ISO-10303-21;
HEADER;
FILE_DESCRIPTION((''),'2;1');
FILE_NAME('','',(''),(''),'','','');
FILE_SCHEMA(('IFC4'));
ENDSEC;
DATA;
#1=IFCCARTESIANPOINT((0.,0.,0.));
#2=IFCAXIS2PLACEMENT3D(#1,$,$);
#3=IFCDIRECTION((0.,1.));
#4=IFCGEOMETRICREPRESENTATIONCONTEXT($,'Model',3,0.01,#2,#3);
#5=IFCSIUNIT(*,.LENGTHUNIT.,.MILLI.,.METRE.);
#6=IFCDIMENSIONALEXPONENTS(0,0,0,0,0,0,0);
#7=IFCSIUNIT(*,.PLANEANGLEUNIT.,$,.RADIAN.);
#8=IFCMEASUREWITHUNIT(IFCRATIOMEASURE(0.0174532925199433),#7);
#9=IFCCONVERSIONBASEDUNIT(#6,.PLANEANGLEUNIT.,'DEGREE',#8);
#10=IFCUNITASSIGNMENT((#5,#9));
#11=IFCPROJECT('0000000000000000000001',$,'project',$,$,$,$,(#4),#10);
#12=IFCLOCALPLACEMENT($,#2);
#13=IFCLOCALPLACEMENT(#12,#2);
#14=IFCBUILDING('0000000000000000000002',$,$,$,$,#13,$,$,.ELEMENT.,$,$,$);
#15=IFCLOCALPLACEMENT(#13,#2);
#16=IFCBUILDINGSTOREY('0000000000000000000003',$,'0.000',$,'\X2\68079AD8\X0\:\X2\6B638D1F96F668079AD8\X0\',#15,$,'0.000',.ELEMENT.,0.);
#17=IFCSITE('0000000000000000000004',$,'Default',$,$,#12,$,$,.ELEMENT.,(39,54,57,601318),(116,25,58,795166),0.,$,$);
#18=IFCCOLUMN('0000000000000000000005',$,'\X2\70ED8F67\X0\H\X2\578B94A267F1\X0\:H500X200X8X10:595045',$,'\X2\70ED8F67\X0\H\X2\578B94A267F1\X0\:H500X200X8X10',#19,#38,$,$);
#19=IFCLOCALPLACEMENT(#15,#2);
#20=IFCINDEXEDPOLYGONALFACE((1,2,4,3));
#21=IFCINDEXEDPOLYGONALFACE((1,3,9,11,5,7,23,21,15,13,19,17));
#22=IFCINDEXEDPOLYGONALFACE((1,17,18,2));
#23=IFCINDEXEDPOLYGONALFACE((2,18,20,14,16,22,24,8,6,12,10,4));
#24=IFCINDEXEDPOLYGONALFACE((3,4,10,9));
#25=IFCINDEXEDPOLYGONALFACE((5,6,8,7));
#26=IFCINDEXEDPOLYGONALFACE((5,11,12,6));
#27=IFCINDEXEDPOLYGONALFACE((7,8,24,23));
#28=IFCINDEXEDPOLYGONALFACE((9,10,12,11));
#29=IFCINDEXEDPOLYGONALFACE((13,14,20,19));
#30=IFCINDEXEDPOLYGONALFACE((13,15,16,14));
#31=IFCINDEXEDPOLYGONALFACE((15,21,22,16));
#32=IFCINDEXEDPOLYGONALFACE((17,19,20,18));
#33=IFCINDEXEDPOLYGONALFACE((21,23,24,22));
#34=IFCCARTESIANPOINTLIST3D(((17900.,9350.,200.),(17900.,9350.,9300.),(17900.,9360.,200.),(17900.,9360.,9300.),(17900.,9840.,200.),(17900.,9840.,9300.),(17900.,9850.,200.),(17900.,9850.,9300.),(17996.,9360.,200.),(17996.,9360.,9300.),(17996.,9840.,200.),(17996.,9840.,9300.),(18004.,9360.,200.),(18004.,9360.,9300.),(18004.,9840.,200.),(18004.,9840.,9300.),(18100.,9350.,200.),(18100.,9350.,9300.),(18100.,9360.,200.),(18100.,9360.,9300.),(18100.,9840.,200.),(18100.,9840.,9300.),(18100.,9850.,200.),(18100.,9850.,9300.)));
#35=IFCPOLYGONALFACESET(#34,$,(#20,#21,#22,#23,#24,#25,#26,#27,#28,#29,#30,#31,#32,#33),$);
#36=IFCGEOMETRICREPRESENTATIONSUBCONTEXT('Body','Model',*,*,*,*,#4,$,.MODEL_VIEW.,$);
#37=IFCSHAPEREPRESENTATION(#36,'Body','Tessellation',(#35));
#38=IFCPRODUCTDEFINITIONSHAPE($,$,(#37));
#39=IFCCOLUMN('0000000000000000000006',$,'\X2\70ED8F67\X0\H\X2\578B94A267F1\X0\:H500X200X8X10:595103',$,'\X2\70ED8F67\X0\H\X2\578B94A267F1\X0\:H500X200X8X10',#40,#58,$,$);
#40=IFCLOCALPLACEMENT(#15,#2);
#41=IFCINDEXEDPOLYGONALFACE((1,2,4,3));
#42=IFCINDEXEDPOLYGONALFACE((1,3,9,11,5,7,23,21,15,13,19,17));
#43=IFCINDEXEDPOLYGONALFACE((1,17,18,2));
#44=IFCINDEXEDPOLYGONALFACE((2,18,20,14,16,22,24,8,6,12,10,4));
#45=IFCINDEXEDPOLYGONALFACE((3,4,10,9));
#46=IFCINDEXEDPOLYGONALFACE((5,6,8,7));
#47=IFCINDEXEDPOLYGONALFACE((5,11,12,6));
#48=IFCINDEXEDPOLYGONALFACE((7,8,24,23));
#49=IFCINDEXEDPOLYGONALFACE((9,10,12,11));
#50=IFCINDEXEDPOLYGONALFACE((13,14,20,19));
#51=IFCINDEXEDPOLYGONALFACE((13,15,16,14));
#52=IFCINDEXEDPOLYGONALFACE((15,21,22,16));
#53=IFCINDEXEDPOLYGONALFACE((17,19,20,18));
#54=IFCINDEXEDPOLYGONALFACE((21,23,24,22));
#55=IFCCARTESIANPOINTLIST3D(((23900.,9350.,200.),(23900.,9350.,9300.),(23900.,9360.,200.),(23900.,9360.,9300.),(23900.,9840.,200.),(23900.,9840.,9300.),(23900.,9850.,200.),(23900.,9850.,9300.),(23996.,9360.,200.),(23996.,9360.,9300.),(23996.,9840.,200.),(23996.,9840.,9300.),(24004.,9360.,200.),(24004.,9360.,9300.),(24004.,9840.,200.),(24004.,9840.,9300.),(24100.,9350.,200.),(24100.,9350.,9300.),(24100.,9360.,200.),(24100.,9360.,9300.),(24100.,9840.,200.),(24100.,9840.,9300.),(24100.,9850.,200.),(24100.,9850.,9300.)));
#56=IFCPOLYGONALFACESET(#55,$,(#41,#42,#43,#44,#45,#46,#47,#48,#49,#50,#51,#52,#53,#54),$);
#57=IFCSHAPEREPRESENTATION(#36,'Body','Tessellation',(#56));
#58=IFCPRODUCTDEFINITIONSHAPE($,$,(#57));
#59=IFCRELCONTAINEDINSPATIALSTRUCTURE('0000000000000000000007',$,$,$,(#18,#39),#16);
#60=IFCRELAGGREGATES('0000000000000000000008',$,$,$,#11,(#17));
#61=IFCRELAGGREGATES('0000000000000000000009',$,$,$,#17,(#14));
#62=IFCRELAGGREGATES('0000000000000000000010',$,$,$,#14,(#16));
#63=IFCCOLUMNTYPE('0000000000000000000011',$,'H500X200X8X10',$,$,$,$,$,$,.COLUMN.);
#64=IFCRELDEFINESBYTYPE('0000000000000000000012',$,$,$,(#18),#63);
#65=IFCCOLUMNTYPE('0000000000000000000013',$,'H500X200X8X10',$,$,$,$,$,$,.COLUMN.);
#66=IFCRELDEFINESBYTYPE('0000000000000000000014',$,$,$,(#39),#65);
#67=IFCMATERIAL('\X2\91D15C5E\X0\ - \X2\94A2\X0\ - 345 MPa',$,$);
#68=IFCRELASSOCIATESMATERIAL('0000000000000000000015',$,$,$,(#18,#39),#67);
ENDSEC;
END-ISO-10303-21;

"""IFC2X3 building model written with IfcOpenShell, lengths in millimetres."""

from ifc_helpers import new_model, entity, si_unit, converted_unit, direction, frame, frame_2d, origin, place, context, subcontext, project, spatial, i_section, extrude, source, transform, mapped, material, type_object, type_shapes, element, save


model = new_model("IFC2X3")

# Units and contexts
model_context = context("Model", 3, precision=0.01, world=origin(), true_north=direction((0.0, 1.0)))
body_context = subcontext(model_context, "Body", "Model", "MODEL_VIEW")
ifc_project = project(units=[si_unit("LENGTHUNIT", "METRE", prefix="MILLI"), converted_unit("PLANEANGLEUNIT", "DEGREE", entity("IfcRatioMeasure", 0.0174532925199433), si_unit("PLANEANGLEUNIT", "RADIAN"), dimensions=[0, 0, 0, 0, 0, 0, 0])], contexts=[model_context])

# Site, building, storey
site_placement = place(None, origin())
site = spatial("IfcSite", under=ifc_project, at=site_placement, Name="Default", CompositionType="ELEMENT", RefLatitude=(39, 54, 57, 601318), RefLongitude=(116, 25, 58, 795166), RefElevation=0.0)
building_placement = place(site_placement, origin())
building = spatial("IfcBuilding", under=site, at=building_placement, CompositionType="ELEMENT")
storey_placement = place(building_placement, origin())
storey = spatial("IfcBuildingStorey", under=building, at=storey_placement, Name="0.000", ObjectType="标高:正负零标高", LongName="0.000", CompositionType="ELEMENT", Elevation=0.0)

# Columns
ifc_material_1 = material(Name="金属 - 钢 - 345 MPa")
column_type_1 = type_object("IfcColumnType", Name="H500X200X8X10", PredefinedType="COLUMN")
shared_shape_1 = source(origin(), body_context, "Body", "SweptSolid", [
    extrude(i_section(OverallWidth=200.0, OverallDepth=500.0, WebThickness=8.0, FlangeThickness=10.0, at=frame_2d((0.0, 0.0), x_axis=(0.0, 1.0))), frame((18000.0, 9600.0, 200.0), z_axis=(0.0, 0.0, 1.0), x_axis=(0.0, -1.0, 0.0)), (0.0, 0.0, 1.0), 9100.0),
])
type_shapes(column_type_1, [shared_shape_1])
column_1_placement = place(storey_placement, origin())
element("IfcColumn", 1, at=column_1_placement, inside=storey, type_object=column_type_1, material=ifc_material_1, Name="热轧H型钢柱:H500X200X8X10:595045", ObjectType="热轧H型钢柱:H500X200X8X10", context=body_context, shape_type="MappedRepresentation", body=[
    mapped(shared_shape_1, transform((0.0, 0.0, 0.0), scale=1.0)),
])
column_type_2 = type_object("IfcColumnType", Name="H500X200X8X10", PredefinedType="COLUMN")
shared_shape_2 = source(origin(), body_context, "Body", "SweptSolid", [
    extrude(i_section(OverallWidth=200.0, OverallDepth=500.0, WebThickness=8.0, FlangeThickness=10.0, at=frame_2d((0.0, 0.0), x_axis=(0.0, 1.0))), frame((24000.0, 9600.0, 200.0), z_axis=(0.0, 0.0, 1.0), x_axis=(0.0, -1.0, 0.0)), (0.0, 0.0, 1.0), 9100.0),
])
type_shapes(column_type_2, [shared_shape_2])
column_2_placement = place(storey_placement, origin())
element("IfcColumn", 2, at=column_2_placement, inside=storey, type_object=column_type_2, material=ifc_material_1, Name="热轧H型钢柱:H500X200X8X10:595103", ObjectType="热轧H型钢柱:H500X200X8X10", context=body_context, shape_type="MappedRepresentation", body=[
    mapped(shared_shape_2, transform((0.0, 0.0, 0.0), scale=1.0)),
])

save(model, "model.ifc")
